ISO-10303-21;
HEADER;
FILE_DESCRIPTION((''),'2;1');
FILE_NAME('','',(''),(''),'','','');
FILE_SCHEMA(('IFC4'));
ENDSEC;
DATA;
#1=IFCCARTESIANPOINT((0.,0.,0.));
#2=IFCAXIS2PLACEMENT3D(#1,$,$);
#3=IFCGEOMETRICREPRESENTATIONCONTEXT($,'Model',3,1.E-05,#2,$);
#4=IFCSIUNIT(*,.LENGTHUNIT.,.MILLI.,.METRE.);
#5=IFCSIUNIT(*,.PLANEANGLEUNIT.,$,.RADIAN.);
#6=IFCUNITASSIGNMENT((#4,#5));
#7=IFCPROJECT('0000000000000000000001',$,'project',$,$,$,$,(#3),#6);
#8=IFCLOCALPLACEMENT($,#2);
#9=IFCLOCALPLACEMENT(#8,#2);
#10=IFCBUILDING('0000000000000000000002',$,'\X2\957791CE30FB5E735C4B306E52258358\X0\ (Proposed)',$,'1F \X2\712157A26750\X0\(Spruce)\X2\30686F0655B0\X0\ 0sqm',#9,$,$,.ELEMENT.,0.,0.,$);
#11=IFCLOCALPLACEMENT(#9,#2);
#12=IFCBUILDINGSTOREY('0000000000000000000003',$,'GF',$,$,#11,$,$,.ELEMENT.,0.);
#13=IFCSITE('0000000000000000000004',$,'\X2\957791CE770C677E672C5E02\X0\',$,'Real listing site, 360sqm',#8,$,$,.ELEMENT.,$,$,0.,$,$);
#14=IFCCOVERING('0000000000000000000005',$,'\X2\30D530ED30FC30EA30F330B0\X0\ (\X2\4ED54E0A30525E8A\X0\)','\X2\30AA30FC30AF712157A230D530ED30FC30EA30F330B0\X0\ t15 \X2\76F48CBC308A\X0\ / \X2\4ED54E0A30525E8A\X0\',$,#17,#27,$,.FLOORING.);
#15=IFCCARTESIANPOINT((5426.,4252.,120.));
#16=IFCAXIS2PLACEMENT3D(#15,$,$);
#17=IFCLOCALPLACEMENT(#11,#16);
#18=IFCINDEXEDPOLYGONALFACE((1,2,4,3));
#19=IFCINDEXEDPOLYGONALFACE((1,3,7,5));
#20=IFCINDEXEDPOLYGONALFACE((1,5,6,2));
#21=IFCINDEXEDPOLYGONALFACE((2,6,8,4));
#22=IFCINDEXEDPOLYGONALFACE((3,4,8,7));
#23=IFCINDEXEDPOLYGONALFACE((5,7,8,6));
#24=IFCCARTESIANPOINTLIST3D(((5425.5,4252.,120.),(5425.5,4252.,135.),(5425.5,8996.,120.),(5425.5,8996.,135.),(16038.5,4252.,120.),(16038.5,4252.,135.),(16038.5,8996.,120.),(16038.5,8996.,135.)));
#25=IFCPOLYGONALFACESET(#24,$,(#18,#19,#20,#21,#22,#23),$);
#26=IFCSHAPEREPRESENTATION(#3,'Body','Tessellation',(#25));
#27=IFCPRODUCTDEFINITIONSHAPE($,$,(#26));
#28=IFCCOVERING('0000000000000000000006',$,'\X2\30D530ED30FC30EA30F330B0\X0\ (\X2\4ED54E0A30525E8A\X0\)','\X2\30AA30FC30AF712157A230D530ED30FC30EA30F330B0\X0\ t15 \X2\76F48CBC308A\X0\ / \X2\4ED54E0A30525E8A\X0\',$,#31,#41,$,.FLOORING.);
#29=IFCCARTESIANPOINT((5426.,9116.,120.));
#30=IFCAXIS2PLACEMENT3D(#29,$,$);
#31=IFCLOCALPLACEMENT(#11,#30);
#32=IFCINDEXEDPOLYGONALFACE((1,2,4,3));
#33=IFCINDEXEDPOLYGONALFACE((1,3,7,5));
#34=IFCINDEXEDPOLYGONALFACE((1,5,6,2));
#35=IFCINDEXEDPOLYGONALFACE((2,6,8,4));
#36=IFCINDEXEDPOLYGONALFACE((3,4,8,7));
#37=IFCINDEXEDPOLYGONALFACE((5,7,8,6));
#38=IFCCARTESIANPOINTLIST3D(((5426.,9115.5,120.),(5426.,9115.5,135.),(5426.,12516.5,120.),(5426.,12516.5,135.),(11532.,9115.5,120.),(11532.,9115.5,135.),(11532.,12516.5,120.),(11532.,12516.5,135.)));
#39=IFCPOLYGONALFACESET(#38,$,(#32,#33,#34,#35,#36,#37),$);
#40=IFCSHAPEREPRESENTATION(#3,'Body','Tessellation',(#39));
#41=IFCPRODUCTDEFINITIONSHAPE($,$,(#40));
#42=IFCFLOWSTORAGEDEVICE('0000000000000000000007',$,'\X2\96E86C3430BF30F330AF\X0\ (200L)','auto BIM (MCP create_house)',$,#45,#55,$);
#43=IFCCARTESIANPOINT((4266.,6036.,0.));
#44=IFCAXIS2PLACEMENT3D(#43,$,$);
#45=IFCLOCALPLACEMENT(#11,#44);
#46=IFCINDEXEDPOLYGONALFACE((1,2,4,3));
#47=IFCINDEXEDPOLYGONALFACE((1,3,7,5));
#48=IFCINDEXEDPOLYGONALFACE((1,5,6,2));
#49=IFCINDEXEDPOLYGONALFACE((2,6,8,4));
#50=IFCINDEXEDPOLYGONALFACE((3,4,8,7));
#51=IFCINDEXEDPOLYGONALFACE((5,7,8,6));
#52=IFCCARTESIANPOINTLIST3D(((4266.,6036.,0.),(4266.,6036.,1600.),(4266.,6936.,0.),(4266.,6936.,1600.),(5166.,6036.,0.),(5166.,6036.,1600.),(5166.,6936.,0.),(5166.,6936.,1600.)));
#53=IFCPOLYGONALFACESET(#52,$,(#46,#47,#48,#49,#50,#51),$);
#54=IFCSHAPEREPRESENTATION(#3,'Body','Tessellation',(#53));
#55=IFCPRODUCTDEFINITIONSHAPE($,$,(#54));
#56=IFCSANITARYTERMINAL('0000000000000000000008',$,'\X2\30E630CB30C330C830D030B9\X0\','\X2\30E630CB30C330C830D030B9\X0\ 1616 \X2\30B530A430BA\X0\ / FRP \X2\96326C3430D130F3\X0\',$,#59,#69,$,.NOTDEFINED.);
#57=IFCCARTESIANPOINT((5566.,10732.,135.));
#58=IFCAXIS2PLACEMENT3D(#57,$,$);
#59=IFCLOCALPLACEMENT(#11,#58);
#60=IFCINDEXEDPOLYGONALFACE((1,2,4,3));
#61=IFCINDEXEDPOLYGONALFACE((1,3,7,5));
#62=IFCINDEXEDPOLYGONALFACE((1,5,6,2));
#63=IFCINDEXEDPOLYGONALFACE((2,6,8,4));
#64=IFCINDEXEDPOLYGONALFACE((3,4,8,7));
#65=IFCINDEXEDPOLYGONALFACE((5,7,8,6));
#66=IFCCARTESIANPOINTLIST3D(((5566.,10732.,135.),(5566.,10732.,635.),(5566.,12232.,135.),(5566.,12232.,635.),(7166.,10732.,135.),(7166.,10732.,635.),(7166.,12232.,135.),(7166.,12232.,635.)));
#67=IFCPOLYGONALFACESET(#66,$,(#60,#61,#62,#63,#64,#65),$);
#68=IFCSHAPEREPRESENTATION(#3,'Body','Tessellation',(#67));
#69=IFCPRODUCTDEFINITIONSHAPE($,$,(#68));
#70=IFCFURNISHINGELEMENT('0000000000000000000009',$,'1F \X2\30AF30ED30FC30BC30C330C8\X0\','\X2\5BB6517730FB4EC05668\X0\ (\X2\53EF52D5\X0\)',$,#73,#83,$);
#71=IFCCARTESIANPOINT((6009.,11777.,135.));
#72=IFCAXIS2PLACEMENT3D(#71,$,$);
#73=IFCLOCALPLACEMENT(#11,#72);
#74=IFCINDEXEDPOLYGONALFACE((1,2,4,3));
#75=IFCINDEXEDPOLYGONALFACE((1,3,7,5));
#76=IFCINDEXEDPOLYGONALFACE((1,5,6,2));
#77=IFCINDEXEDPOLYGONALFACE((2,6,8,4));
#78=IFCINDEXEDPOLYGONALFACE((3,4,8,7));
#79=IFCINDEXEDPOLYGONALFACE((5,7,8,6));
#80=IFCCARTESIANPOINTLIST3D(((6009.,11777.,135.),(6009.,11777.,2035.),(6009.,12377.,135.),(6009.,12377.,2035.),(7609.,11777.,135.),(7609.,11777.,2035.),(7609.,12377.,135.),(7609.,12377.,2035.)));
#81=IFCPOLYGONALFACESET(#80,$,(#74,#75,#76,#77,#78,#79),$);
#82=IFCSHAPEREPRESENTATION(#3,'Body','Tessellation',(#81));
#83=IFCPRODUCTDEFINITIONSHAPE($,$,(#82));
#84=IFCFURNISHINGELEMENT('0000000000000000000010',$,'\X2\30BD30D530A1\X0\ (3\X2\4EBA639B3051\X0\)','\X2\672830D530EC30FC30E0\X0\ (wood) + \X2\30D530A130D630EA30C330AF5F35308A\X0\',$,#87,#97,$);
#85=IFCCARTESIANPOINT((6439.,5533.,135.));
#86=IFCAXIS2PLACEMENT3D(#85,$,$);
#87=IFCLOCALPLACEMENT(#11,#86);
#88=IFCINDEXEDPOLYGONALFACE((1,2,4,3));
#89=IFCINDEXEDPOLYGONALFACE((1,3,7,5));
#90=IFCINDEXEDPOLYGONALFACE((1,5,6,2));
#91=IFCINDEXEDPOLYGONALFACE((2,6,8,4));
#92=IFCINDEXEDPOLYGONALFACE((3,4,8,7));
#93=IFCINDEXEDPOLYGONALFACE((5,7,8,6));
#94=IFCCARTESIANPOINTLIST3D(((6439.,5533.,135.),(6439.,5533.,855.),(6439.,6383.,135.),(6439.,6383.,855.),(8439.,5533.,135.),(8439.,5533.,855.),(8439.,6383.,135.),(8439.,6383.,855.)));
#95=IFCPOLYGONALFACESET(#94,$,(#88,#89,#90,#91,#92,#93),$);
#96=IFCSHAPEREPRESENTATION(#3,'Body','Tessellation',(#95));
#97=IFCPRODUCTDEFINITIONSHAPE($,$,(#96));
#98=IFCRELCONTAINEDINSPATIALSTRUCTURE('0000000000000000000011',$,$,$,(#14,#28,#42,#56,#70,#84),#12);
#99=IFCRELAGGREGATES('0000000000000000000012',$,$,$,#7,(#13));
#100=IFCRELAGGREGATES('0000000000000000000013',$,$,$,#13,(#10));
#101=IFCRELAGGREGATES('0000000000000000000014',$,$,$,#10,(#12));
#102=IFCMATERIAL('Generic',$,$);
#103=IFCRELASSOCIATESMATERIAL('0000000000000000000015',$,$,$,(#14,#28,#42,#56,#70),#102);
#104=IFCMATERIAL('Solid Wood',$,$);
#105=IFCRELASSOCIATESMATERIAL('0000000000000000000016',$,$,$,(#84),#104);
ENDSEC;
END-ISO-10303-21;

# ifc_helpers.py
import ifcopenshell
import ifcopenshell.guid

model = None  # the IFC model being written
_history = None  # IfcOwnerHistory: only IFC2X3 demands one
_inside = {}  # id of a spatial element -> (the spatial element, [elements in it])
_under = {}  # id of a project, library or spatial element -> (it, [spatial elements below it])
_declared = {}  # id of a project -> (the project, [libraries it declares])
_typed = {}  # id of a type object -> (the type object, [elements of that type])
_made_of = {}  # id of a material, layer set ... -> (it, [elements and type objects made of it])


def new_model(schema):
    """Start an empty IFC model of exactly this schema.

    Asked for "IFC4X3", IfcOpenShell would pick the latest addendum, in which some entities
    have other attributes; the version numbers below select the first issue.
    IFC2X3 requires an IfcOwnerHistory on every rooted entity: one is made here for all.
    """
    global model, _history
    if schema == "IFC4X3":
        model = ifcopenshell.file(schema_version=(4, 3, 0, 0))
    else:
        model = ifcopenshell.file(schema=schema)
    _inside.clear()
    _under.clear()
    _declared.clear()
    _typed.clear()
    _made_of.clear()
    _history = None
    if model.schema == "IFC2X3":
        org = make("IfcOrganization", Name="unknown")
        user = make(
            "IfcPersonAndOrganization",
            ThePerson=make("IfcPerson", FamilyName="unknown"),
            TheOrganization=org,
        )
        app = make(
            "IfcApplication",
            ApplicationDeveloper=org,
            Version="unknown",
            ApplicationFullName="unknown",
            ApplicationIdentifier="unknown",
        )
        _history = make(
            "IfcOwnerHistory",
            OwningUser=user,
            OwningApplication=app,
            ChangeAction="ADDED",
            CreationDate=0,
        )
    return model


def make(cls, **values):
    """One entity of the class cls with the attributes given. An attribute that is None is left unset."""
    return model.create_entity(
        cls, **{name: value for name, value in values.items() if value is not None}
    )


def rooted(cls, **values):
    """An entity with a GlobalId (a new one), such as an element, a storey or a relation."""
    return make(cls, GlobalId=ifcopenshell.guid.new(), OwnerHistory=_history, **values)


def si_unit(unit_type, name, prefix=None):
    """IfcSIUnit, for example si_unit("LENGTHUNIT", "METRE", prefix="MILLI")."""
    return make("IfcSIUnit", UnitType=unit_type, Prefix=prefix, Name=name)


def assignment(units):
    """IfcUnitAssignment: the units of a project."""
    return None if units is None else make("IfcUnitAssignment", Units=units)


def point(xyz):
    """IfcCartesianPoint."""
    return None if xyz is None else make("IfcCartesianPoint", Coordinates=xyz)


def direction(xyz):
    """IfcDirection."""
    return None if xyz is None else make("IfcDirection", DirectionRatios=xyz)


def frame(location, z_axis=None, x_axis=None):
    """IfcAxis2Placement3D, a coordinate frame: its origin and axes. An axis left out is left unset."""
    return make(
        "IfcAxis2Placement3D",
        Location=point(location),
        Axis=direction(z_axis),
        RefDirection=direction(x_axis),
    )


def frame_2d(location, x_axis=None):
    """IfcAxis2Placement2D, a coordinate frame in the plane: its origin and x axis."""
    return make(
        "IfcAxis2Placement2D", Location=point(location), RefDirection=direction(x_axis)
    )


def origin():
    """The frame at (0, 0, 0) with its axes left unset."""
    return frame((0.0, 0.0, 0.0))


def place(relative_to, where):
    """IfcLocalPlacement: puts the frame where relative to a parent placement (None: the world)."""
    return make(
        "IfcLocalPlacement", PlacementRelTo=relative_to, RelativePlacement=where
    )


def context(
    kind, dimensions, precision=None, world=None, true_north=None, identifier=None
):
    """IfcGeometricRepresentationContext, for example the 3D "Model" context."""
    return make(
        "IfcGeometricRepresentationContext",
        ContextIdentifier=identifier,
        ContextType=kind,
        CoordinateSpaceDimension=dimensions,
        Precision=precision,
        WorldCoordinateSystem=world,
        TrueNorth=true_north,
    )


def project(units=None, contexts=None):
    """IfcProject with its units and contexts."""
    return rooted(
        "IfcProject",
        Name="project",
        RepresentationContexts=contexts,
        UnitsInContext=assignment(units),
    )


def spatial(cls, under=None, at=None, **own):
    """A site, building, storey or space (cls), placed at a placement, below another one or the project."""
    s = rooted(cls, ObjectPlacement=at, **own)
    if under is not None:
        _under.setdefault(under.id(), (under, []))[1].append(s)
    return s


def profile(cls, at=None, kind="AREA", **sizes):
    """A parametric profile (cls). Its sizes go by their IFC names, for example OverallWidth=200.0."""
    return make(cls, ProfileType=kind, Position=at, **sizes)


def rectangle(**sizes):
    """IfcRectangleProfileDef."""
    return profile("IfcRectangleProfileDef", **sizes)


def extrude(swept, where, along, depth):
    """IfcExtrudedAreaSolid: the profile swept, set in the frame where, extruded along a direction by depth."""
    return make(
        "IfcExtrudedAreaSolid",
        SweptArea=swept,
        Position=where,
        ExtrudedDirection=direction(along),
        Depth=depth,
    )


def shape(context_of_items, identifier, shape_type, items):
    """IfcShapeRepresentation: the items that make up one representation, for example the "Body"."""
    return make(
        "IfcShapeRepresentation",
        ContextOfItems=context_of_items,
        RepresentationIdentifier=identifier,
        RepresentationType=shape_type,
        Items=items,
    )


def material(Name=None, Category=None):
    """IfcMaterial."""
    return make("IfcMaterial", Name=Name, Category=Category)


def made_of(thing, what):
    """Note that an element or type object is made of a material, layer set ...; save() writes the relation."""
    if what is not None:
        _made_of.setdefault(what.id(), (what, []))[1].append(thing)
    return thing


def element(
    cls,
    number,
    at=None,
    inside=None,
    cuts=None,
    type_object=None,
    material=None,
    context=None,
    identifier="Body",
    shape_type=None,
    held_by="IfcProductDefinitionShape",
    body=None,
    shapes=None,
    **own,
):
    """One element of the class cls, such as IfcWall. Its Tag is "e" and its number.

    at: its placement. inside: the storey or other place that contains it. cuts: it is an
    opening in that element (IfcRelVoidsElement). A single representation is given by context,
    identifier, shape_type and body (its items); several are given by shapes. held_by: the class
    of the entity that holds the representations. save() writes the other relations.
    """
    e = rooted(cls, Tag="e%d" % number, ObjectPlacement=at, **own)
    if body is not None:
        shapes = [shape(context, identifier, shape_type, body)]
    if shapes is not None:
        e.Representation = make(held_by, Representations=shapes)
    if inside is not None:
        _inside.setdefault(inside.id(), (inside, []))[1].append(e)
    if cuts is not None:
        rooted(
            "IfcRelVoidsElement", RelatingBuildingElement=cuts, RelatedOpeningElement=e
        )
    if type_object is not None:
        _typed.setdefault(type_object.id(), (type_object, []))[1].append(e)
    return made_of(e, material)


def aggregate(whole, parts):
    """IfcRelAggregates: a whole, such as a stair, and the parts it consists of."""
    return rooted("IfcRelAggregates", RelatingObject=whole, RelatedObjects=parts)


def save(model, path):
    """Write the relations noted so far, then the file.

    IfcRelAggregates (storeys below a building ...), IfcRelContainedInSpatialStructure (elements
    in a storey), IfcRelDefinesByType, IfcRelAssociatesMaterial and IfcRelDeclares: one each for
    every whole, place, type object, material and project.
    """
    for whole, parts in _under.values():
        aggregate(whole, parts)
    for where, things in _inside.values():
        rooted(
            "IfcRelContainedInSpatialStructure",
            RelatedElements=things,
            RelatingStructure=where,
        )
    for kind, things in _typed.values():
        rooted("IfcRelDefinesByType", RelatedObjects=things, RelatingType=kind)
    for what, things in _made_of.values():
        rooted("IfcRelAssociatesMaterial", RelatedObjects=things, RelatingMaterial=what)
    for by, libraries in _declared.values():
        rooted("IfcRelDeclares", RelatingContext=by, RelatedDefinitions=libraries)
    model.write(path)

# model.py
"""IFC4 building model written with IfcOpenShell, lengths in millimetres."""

from ifc_helpers import new_model, si_unit, frame, frame_2d, origin, place, context, project, spatial, rectangle, extrude, material, element, save


model = new_model("IFC4")

# Units and contexts
model_context = context("Model", 3, precision=1e-05, world=origin())
ifc_project = project(units=[si_unit("LENGTHUNIT", "METRE", prefix="MILLI"), si_unit("PLANEANGLEUNIT", "RADIAN")], contexts=[model_context])

# Site, building, storey
site_placement = place(None, origin())
site = spatial("IfcSite", under=ifc_project, at=site_placement, Name="長野県松本市", ObjectType="Real listing site, 360sqm", CompositionType="ELEMENT", RefElevation=0.0)
building_placement = place(site_placement, origin())
building = spatial("IfcBuilding", under=site, at=building_placement, Name="長野・平屋の別荘 (Proposed)", ObjectType="1F 無垢材(Spruce)と漆喰 0sqm", CompositionType="ELEMENT", ElevationOfRefHeight=0.0, ElevationOfTerrain=0.0)
storey_placement = place(building_placement, origin())
storey = spatial("IfcBuildingStorey", under=building, at=storey_placement, Name="GF", CompositionType="ELEMENT", Elevation=0.0)

# Shared definitions
ifc_material_1 = material(Name="Solid Wood")

# Coverings
ifc_material_2 = material(Name="Generic")
covering_1_placement = place(storey_placement, frame((5426.0, 4252.0, 120.0)))
element("IfcCovering", 1, at=covering_1_placement, inside=storey, material=ifc_material_2, Name="フローリング (仕上げ床)", Description="オーク無垢フローリング t15 直貼り / 仕上げ床", PredefinedType="FLOORING", context=model_context, shape_type="SweptSolid", body=[
    extrude(rectangle(XDim=10613.0, YDim=4744.0, at=frame_2d((5306.0, 2372.0))), frame((5426.0, 4252.0, 120.0)), (0.0, 0.0, 1.0), 15.0),
])
covering_2_placement = place(storey_placement, frame((5426.0, 9116.0, 120.0)))
element("IfcCovering", 2, at=covering_2_placement, inside=storey, material=ifc_material_2, Name="フローリング (仕上げ床)", Description="オーク無垢フローリング t15 直貼り / 仕上げ床", PredefinedType="FLOORING", context=model_context, shape_type="SweptSolid", body=[
    extrude(rectangle(XDim=6106.0, YDim=3401.0, at=frame_2d((3053.0, 1700.0))), frame((5426.0, 9116.0, 120.0)), (0.0, 0.0, 1.0), 15.0),
])

# Flow storage device
flow_storage_device_placement = place(storey_placement, frame((4266.0, 6036.0, 0.0)))
element("IfcFlowStorageDevice", 3, at=flow_storage_device_placement, inside=storey, material=ifc_material_2, Name="雨水タンク (200L)", Description="auto BIM (MCP create_house)", context=model_context, shape_type="SweptSolid", body=[
    extrude(rectangle(XDim=900.0, YDim=900.0, at=frame_2d((450.0, 450.0))), frame((4266.0, 6036.0, 0.0)), (0.0, 0.0, 1.0), 1600.0),
])

# Sanitary terminal
sanitary_terminal_placement = place(storey_placement, frame((5566.0, 10732.0, 135.0)))
element("IfcSanitaryTerminal", 4, at=sanitary_terminal_placement, inside=storey, material=ifc_material_2, Name="ユニットバス", Description="ユニットバス 1616 サイズ / FRP 防水パン", PredefinedType="NOTDEFINED", context=model_context, shape_type="SweptSolid", body=[
    extrude(rectangle(XDim=1600.0, YDim=1500.0, at=frame_2d((800.0, 750.0))), frame((5566.0, 10732.0, 135.0)), (0.0, 0.0, 1.0), 500.0),
])

# Furnishing elements
furnishing_1_placement = place(storey_placement, frame((6009.0, 11777.0, 135.0)))
element("IfcFurnishingElement", 5, at=furnishing_1_placement, inside=storey, material=ifc_material_2, Name="1F クローゼット", Description="家具・什器 (可動)", context=model_context, shape_type="SweptSolid", body=[
    extrude(rectangle(XDim=1600.0, YDim=600.0, at=frame_2d((800.0, 300.0))), frame((6009.0, 11777.0, 135.0)), (0.0, 0.0, 1.0), 1900.0),
])
furnishing_2_placement = place(storey_placement, frame((6439.0, 5533.0, 135.0)))
element("IfcFurnishingElement", 6, at=furnishing_2_placement, inside=storey, material=ifc_material_1, Name="ソファ (3人掛け)", Description="木フレーム (wood) + ファブリック張り", context=model_context, shape_type="SweptSolid", body=[
    extrude(rectangle(XDim=2000.0, YDim=850.0, at=frame_2d((1000.0, 425.0))), frame((6439.0, 5533.0, 135.0)), (0.0, 0.0, 1.0), 720.0),
])

save(model, "model.ifc")
